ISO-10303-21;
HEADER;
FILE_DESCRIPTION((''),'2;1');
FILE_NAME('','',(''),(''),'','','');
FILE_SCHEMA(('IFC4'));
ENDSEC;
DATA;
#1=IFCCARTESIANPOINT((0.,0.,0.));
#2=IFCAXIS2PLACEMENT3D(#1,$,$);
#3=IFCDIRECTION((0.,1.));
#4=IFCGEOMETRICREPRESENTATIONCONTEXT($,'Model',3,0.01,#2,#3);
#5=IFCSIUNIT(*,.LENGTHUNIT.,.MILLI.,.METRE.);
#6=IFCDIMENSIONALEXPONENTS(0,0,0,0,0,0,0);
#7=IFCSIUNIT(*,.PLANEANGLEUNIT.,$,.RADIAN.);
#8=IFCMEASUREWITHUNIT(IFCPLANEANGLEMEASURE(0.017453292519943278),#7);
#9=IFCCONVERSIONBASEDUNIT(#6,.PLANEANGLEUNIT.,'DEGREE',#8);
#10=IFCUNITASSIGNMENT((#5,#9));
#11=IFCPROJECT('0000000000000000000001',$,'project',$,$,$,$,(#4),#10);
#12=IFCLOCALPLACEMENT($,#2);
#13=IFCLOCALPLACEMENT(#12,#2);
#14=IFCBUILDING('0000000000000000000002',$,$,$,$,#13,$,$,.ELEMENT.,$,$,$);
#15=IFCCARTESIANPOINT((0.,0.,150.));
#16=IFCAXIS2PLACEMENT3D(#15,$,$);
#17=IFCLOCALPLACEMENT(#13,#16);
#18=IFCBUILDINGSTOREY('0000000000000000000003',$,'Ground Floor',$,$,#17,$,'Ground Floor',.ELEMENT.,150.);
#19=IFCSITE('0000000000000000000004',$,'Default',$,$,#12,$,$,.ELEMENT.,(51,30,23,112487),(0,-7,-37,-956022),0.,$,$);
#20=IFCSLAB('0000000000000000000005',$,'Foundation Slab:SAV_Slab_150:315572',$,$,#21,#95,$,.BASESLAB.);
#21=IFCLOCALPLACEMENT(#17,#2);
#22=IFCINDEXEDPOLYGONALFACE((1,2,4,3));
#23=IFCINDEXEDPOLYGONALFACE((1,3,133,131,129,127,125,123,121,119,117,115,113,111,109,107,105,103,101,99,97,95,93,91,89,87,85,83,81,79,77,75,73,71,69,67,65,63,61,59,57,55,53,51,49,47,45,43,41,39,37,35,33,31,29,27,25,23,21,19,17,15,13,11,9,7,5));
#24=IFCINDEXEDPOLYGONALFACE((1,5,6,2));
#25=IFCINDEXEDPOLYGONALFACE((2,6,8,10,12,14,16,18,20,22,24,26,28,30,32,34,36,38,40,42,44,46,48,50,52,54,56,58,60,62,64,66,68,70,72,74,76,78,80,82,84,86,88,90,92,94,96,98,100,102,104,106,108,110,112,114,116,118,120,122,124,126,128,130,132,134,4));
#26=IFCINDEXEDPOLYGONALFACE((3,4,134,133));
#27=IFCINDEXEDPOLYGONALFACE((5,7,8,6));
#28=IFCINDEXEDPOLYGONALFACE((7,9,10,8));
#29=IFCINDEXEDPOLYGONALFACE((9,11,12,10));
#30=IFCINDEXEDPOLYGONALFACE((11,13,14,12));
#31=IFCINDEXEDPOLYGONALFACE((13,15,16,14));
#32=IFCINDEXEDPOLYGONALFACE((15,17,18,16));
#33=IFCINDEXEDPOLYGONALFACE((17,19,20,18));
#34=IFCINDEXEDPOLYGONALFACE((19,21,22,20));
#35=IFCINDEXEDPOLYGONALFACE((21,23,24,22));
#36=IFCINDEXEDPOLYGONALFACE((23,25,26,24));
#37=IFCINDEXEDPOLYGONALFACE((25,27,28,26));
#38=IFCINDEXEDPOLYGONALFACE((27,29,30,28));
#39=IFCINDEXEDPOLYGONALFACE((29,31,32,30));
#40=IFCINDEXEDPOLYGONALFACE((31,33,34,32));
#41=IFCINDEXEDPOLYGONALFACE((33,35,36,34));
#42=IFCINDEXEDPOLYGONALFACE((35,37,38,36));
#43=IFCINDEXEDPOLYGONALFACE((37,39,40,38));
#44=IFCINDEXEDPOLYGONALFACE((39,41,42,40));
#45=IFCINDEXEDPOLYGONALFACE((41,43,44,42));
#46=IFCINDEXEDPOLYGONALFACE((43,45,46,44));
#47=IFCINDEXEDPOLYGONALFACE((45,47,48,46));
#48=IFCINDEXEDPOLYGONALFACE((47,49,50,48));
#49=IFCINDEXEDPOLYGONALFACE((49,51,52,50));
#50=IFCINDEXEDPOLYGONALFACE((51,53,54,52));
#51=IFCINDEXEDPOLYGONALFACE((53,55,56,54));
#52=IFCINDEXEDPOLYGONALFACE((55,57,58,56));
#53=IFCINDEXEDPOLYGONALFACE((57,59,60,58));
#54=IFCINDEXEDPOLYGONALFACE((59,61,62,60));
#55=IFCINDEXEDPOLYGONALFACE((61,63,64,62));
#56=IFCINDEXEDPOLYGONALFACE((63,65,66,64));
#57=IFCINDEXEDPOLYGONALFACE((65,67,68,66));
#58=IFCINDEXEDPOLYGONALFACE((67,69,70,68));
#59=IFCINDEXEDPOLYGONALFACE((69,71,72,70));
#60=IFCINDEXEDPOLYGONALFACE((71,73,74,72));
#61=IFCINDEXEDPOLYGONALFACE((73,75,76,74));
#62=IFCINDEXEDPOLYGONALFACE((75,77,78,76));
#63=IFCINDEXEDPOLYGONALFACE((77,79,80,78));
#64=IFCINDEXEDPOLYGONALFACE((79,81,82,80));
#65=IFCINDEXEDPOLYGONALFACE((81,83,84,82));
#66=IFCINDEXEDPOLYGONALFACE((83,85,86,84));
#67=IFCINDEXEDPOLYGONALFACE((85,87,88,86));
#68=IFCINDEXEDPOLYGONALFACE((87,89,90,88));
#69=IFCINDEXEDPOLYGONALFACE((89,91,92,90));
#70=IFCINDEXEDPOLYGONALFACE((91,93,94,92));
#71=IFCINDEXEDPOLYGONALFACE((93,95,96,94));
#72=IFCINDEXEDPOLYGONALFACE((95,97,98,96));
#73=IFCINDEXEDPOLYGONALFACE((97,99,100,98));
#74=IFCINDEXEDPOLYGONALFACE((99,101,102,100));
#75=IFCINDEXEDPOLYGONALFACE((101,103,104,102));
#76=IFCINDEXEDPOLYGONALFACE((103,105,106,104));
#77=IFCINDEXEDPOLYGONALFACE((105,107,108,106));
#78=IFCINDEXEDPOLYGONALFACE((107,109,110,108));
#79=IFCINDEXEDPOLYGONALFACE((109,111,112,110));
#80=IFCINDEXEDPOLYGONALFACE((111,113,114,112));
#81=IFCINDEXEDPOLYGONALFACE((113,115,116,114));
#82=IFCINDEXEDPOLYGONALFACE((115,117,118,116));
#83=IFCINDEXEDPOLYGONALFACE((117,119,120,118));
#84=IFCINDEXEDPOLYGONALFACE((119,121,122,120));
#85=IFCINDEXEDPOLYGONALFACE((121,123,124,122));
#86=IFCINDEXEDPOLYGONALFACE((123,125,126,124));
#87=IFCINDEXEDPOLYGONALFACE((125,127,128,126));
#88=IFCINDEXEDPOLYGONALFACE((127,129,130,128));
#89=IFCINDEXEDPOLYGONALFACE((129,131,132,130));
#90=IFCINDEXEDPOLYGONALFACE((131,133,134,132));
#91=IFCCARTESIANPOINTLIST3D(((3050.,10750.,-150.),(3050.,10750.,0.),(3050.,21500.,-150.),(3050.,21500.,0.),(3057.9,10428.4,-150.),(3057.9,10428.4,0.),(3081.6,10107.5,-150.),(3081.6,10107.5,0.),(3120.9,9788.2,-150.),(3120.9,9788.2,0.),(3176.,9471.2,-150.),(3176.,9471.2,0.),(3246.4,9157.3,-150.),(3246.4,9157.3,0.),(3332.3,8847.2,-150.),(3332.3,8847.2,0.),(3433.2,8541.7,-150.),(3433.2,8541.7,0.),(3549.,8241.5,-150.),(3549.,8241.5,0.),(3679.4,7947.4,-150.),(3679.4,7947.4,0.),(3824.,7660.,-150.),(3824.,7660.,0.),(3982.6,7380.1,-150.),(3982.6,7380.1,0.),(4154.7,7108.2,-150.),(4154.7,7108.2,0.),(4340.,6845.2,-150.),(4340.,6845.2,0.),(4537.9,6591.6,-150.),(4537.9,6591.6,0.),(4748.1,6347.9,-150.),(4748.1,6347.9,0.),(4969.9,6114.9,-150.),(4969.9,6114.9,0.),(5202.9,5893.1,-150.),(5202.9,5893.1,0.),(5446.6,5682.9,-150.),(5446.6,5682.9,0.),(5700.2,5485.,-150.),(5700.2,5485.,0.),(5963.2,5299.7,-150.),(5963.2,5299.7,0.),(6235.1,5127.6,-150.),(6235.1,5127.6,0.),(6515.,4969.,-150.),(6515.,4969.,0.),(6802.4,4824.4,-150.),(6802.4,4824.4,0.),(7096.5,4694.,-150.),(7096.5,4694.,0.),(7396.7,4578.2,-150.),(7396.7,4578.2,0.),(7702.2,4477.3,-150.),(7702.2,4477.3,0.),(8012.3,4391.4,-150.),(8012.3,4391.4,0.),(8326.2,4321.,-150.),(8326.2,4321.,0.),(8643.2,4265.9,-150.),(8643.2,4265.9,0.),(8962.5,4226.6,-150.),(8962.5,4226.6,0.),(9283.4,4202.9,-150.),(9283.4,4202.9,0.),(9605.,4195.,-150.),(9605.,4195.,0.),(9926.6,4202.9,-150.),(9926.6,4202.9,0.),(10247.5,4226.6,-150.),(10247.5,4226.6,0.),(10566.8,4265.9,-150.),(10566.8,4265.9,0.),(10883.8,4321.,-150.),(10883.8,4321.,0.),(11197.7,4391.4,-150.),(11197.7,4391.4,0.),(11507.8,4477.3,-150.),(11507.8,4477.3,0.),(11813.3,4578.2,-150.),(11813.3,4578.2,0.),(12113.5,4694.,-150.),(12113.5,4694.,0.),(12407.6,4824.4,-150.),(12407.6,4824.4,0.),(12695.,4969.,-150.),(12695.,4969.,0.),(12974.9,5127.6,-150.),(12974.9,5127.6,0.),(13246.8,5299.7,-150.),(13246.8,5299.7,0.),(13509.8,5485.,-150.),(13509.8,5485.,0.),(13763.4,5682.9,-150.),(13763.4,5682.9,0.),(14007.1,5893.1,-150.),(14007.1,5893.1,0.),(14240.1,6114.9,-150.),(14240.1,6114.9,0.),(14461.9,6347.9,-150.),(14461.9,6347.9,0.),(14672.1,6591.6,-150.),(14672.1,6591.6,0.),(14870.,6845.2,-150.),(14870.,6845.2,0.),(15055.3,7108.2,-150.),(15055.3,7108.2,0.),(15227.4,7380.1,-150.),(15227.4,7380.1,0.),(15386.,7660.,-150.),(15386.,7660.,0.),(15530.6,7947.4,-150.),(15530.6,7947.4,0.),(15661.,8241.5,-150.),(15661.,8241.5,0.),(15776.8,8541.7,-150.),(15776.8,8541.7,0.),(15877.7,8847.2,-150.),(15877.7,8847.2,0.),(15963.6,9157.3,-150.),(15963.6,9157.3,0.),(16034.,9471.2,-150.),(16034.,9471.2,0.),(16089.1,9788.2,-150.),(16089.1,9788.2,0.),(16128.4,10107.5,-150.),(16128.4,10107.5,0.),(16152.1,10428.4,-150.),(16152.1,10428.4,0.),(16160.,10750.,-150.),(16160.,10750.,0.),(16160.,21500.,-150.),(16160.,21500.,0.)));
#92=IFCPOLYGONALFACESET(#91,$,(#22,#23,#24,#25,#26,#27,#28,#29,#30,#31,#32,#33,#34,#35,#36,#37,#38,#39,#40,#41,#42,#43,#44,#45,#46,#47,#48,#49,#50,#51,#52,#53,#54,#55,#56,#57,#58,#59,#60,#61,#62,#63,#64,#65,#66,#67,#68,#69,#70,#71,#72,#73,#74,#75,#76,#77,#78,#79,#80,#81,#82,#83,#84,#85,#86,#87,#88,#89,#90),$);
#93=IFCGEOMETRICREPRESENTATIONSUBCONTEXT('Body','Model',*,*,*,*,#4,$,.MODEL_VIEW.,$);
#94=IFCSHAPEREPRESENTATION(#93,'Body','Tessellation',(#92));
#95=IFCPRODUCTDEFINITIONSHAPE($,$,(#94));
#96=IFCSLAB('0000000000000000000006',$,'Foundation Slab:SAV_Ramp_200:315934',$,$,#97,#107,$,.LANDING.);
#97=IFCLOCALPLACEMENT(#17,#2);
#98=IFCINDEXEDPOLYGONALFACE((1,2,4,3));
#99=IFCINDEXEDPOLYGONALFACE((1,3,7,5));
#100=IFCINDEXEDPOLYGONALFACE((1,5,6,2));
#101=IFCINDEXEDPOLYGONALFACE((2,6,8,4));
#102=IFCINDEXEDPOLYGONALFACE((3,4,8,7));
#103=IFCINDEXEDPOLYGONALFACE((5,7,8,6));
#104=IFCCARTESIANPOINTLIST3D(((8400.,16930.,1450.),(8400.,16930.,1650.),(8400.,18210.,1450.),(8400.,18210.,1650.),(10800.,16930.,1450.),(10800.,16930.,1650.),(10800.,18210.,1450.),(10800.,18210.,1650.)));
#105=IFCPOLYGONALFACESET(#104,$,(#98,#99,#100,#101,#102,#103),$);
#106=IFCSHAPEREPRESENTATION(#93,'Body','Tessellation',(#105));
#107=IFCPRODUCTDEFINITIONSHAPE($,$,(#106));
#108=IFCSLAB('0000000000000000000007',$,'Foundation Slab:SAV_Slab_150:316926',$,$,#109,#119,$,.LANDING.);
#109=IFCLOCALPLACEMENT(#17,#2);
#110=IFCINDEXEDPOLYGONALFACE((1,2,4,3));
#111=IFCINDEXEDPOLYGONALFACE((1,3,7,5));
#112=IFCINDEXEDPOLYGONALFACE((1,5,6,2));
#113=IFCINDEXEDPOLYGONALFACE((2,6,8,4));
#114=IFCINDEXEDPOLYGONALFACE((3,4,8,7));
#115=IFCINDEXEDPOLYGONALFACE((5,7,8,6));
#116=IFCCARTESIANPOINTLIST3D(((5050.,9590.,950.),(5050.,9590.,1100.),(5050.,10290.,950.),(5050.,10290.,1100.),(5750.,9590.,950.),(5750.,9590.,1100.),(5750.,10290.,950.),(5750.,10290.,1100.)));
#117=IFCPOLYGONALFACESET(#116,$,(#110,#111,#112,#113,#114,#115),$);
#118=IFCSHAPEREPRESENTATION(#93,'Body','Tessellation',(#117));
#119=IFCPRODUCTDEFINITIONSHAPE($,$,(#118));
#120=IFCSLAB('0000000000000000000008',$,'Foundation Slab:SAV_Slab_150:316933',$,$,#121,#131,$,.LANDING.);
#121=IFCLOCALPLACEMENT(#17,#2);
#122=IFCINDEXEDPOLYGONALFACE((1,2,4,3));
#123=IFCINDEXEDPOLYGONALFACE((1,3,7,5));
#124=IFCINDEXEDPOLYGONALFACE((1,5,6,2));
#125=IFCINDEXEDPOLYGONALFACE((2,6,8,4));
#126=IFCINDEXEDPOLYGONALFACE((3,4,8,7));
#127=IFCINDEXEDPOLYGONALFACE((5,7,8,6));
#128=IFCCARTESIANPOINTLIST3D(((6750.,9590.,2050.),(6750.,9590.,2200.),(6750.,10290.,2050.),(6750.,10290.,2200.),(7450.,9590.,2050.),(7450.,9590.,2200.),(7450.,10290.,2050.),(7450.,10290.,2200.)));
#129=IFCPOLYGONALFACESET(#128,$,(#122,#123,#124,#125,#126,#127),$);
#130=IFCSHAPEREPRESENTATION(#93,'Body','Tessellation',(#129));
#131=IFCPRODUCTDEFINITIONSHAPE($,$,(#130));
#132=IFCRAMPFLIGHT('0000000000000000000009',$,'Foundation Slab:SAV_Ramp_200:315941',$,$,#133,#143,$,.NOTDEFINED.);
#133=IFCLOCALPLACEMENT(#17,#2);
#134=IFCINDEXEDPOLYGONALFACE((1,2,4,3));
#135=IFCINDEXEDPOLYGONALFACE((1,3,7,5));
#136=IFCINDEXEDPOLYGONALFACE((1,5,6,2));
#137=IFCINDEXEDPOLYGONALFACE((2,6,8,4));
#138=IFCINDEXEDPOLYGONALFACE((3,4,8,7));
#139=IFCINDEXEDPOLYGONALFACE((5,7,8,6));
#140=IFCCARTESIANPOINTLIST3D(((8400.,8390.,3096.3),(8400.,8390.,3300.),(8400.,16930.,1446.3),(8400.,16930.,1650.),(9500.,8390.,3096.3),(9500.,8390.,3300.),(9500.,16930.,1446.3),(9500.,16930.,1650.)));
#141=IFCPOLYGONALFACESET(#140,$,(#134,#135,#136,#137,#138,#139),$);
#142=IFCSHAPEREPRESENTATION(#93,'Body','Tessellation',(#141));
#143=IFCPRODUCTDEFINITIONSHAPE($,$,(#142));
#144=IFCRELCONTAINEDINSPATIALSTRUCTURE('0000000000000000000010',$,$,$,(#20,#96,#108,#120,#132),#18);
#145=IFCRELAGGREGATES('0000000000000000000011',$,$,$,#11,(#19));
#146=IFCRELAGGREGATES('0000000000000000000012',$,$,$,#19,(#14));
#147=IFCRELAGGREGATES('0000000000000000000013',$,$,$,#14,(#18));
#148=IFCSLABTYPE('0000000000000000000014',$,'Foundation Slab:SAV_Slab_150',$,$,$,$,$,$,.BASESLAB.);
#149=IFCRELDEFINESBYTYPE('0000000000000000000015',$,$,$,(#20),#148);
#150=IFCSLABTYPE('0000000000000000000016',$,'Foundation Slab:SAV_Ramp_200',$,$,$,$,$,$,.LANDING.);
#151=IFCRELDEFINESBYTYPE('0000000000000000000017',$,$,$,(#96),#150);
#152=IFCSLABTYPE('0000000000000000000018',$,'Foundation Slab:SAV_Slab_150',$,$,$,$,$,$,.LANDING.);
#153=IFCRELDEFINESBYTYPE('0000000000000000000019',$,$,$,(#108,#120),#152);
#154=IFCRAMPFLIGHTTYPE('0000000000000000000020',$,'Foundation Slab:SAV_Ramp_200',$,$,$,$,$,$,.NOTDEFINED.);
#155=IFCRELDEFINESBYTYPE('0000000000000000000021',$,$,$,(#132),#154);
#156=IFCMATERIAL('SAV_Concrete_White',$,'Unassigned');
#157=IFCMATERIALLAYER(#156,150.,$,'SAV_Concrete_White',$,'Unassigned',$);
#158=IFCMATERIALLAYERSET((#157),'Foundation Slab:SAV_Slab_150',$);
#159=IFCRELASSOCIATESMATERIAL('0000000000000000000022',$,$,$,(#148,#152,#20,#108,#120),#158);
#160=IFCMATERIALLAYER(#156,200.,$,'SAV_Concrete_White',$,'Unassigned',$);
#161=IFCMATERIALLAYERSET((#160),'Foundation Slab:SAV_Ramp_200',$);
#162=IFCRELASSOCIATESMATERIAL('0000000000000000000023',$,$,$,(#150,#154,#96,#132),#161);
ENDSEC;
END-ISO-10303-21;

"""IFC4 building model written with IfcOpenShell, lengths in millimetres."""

from ifc_helpers import new_model, entity, si_unit, converted_unit, direction, frame, frame_2d, origin, place, context, subcontext, project, spatial, polyline, circle_curve, parameter, trimmed, segment, composite_curve, rectangle, outline, extrude, clip, halfspace, material, layer, layer_set, layer_usage, type_object, element, save


model = new_model("IFC4")

# Units and contexts
model_context = context("Model", 3, precision=0.01, world=origin(), true_north=direction((0.0, 1.0)))
body_context = subcontext(model_context, "Body", "Model", "MODEL_VIEW")
ifc_project = project(units=[si_unit("LENGTHUNIT", "METRE", prefix="MILLI"), converted_unit("PLANEANGLEUNIT", "DEGREE", entity("IfcPlaneAngleMeasure", 0.017453292519943278), si_unit("PLANEANGLEUNIT", "RADIAN"), dimensions=[0, 0, 0, 0, 0, 0, 0])], contexts=[model_context])

# Site, building, storey
site_placement = place(None, origin())
site = spatial("IfcSite", under=ifc_project, at=site_placement, Name="Default", CompositionType="ELEMENT", RefLatitude=(51, 30, 23, 112487), RefLongitude=(0, -7, -37, -956022), RefElevation=0.0)
building_placement = place(site_placement, origin())
building = spatial("IfcBuilding", under=site, at=building_placement, CompositionType="ELEMENT")
storey_placement = place(building_placement, frame((0.0, 0.0, 150.0)))
storey = spatial("IfcBuildingStorey", under=building, at=storey_placement, Name="Ground Floor", LongName="Ground Floor", CompositionType="ELEMENT", Elevation=150.0)

# Slab
ifc_material_1 = material(Name="SAV_Concrete_White", Category="Unassigned")
ifc_layer_1 = layer(ifc_material_1, 150.0, Name="SAV_Concrete_White", Category="Unassigned")
ifc_layer_set_1 = layer_set([ifc_layer_1], Name="Foundation Slab:SAV_Slab_150")
ifc_layer_usage_1 = layer_usage(ifc_layer_set_1, "AXIS3", "POSITIVE", 0.0)
slab_type_1 = type_object("IfcSlabType", Name="Foundation Slab:SAV_Slab_150", PredefinedType="BASESLAB", material=ifc_layer_set_1)
slab_1_placement = place(storey_placement, origin())
element("IfcSlab", 1, at=slab_1_placement, inside=storey, type_object=slab_type_1, material=ifc_layer_usage_1, Name="Foundation Slab:SAV_Slab_150:315572", PredefinedType="BASESLAB", context=body_context, shape_type="SweptSolid", body=[
    extrude(outline(composite_curve([segment(polyline([(-5375.0, -6555.0), (5375.0, -6555.0)]), True, "CONTINUOUS"), segment(polyline([(5375.0, -6555.0), (5375.0, 6555.0)]), True, "CONTINUOUS"), segment(polyline([(5375.0, 6555.0), (-5375.0, 6555.0)]), True, "CONTINUOUS"), segment(trimmed(circle_curve(frame_2d((-5375.0, 0.0), x_axis=(0.0, 1.0)), 6555.0), [parameter(0.0)], [parameter(180.0)], True, "PARAMETER"), True, "CONTINUOUS")], self_intersect=False)), frame((9605.0, 16125.0, 0.0), z_axis=(0.0, 0.0, -1.0), x_axis=(0.0, 1.0, 0.0)), (0.0, 0.0, 1.0), 150.0),
])

# Slabs
ifc_layer_2 = layer(ifc_material_1, 200.0, Name="SAV_Concrete_White", Category="Unassigned")
ifc_layer_set_2 = layer_set([ifc_layer_2], Name="Foundation Slab:SAV_Ramp_200")
ifc_layer_usage_2 = layer_usage(ifc_layer_set_2, "AXIS3", "POSITIVE", 0.0)
slab_type_2 = type_object("IfcSlabType", Name="Foundation Slab:SAV_Ramp_200", PredefinedType="LANDING", material=ifc_layer_set_2)
slab_2_placement = place(storey_placement, origin())
element("IfcSlab", 2, at=slab_2_placement, inside=storey, type_object=slab_type_2, material=ifc_layer_usage_2, Name="Foundation Slab:SAV_Ramp_200:315934", PredefinedType="LANDING", context=body_context, shape_type="SweptSolid", body=[
    extrude(rectangle(XDim=1280.0, YDim=2400.0, at=frame_2d((0.0, 0.0), x_axis=(1.0, 0.0))), frame((9600.0, 17570.0, 1650.0), z_axis=(0.0, 0.0, -1.0), x_axis=(0.0, 1.0, 0.0)), (0.0, 0.0, 1.0), 200.0),
])
ifc_layer_usage_3 = layer_usage(ifc_layer_set_1, "AXIS3", "POSITIVE", 0.0)
slab_type_3 = type_object("IfcSlabType", Name="Foundation Slab:SAV_Slab_150", PredefinedType="LANDING", material=ifc_layer_set_1)
slab_3_placement = place(storey_placement, origin())
element("IfcSlab", 3, at=slab_3_placement, inside=storey, type_object=slab_type_3, material=ifc_layer_usage_3, Name="Foundation Slab:SAV_Slab_150:316926", PredefinedType="LANDING", context=body_context, shape_type="SweptSolid", body=[
    extrude(rectangle(XDim=700.0, YDim=700.0, at=frame_2d((0.0, 0.0), x_axis=(1.0, 0.0))), frame((5400.0, 9940.0, 1100.0), z_axis=(0.0, 0.0, -1.0), x_axis=(0.0, 1.0, 0.0)), (0.0, 0.0, 1.0), 150.0),
])
ifc_layer_usage_4 = layer_usage(ifc_layer_set_1, "AXIS3", "POSITIVE", 0.0)
slab_4_placement = place(storey_placement, origin())
element("IfcSlab", 4, at=slab_4_placement, inside=storey, type_object=slab_type_3, material=ifc_layer_usage_4, Name="Foundation Slab:SAV_Slab_150:316933", PredefinedType="LANDING", context=body_context, shape_type="SweptSolid", body=[
    extrude(rectangle(XDim=700.0, YDim=700.0, at=frame_2d((0.0, 0.0), x_axis=(1.0, 0.0))), frame((7100.0, 9940.0, 2200.0), z_axis=(0.0, 0.0, -1.0), x_axis=(0.0, 1.0, 0.0)), (0.0, 0.0, 1.0), 150.0),
])

# Ramp flight
ramp_flight_type = type_object("IfcRampFlightType", Name="Foundation Slab:SAV_Ramp_200", PredefinedType="NOTDEFINED", material=ifc_layer_set_2)
ifc_layer_usage_5 = layer_usage(ifc_layer_set_2, "AXIS3", "POSITIVE", 0.0)
ramp_flight_1_placement = place(storey_placement, origin())
element("IfcRampFlight", 5, at=ramp_flight_1_placement, inside=storey, type_object=ramp_flight_type, material=ifc_layer_usage_5, Name="Foundation Slab:SAV_Ramp_200:315941", PredefinedType="NOTDEFINED", context=body_context, shape_type="Clipping", body=[
    clip(clip(extrude(rectangle(XDim=8697.9, YDim=1100.0, at=frame_2d((0.0, 0.0), x_axis=(1.0, 0.0))), frame((8950.0, 12660.0, 2475.0), z_axis=(0.0, -0.1897, -0.981842), x_axis=(0.0, 0.981842, -0.1897)), (0.1897, 0.0, 0.981842), 207.5), halfspace(frame((8950.0, 16930.0, 1446.3), z_axis=(0.0, -0.1897, -0.981842), x_axis=(0.0, -0.981842, 0.1897)), False)), halfspace(frame((8950.0, 16930.0, 1650.0), z_axis=(0.0, 0.1897, 0.981842), x_axis=(0.0, 0.981842, -0.1897)), False)),
])

save(model, "model.ifc")
